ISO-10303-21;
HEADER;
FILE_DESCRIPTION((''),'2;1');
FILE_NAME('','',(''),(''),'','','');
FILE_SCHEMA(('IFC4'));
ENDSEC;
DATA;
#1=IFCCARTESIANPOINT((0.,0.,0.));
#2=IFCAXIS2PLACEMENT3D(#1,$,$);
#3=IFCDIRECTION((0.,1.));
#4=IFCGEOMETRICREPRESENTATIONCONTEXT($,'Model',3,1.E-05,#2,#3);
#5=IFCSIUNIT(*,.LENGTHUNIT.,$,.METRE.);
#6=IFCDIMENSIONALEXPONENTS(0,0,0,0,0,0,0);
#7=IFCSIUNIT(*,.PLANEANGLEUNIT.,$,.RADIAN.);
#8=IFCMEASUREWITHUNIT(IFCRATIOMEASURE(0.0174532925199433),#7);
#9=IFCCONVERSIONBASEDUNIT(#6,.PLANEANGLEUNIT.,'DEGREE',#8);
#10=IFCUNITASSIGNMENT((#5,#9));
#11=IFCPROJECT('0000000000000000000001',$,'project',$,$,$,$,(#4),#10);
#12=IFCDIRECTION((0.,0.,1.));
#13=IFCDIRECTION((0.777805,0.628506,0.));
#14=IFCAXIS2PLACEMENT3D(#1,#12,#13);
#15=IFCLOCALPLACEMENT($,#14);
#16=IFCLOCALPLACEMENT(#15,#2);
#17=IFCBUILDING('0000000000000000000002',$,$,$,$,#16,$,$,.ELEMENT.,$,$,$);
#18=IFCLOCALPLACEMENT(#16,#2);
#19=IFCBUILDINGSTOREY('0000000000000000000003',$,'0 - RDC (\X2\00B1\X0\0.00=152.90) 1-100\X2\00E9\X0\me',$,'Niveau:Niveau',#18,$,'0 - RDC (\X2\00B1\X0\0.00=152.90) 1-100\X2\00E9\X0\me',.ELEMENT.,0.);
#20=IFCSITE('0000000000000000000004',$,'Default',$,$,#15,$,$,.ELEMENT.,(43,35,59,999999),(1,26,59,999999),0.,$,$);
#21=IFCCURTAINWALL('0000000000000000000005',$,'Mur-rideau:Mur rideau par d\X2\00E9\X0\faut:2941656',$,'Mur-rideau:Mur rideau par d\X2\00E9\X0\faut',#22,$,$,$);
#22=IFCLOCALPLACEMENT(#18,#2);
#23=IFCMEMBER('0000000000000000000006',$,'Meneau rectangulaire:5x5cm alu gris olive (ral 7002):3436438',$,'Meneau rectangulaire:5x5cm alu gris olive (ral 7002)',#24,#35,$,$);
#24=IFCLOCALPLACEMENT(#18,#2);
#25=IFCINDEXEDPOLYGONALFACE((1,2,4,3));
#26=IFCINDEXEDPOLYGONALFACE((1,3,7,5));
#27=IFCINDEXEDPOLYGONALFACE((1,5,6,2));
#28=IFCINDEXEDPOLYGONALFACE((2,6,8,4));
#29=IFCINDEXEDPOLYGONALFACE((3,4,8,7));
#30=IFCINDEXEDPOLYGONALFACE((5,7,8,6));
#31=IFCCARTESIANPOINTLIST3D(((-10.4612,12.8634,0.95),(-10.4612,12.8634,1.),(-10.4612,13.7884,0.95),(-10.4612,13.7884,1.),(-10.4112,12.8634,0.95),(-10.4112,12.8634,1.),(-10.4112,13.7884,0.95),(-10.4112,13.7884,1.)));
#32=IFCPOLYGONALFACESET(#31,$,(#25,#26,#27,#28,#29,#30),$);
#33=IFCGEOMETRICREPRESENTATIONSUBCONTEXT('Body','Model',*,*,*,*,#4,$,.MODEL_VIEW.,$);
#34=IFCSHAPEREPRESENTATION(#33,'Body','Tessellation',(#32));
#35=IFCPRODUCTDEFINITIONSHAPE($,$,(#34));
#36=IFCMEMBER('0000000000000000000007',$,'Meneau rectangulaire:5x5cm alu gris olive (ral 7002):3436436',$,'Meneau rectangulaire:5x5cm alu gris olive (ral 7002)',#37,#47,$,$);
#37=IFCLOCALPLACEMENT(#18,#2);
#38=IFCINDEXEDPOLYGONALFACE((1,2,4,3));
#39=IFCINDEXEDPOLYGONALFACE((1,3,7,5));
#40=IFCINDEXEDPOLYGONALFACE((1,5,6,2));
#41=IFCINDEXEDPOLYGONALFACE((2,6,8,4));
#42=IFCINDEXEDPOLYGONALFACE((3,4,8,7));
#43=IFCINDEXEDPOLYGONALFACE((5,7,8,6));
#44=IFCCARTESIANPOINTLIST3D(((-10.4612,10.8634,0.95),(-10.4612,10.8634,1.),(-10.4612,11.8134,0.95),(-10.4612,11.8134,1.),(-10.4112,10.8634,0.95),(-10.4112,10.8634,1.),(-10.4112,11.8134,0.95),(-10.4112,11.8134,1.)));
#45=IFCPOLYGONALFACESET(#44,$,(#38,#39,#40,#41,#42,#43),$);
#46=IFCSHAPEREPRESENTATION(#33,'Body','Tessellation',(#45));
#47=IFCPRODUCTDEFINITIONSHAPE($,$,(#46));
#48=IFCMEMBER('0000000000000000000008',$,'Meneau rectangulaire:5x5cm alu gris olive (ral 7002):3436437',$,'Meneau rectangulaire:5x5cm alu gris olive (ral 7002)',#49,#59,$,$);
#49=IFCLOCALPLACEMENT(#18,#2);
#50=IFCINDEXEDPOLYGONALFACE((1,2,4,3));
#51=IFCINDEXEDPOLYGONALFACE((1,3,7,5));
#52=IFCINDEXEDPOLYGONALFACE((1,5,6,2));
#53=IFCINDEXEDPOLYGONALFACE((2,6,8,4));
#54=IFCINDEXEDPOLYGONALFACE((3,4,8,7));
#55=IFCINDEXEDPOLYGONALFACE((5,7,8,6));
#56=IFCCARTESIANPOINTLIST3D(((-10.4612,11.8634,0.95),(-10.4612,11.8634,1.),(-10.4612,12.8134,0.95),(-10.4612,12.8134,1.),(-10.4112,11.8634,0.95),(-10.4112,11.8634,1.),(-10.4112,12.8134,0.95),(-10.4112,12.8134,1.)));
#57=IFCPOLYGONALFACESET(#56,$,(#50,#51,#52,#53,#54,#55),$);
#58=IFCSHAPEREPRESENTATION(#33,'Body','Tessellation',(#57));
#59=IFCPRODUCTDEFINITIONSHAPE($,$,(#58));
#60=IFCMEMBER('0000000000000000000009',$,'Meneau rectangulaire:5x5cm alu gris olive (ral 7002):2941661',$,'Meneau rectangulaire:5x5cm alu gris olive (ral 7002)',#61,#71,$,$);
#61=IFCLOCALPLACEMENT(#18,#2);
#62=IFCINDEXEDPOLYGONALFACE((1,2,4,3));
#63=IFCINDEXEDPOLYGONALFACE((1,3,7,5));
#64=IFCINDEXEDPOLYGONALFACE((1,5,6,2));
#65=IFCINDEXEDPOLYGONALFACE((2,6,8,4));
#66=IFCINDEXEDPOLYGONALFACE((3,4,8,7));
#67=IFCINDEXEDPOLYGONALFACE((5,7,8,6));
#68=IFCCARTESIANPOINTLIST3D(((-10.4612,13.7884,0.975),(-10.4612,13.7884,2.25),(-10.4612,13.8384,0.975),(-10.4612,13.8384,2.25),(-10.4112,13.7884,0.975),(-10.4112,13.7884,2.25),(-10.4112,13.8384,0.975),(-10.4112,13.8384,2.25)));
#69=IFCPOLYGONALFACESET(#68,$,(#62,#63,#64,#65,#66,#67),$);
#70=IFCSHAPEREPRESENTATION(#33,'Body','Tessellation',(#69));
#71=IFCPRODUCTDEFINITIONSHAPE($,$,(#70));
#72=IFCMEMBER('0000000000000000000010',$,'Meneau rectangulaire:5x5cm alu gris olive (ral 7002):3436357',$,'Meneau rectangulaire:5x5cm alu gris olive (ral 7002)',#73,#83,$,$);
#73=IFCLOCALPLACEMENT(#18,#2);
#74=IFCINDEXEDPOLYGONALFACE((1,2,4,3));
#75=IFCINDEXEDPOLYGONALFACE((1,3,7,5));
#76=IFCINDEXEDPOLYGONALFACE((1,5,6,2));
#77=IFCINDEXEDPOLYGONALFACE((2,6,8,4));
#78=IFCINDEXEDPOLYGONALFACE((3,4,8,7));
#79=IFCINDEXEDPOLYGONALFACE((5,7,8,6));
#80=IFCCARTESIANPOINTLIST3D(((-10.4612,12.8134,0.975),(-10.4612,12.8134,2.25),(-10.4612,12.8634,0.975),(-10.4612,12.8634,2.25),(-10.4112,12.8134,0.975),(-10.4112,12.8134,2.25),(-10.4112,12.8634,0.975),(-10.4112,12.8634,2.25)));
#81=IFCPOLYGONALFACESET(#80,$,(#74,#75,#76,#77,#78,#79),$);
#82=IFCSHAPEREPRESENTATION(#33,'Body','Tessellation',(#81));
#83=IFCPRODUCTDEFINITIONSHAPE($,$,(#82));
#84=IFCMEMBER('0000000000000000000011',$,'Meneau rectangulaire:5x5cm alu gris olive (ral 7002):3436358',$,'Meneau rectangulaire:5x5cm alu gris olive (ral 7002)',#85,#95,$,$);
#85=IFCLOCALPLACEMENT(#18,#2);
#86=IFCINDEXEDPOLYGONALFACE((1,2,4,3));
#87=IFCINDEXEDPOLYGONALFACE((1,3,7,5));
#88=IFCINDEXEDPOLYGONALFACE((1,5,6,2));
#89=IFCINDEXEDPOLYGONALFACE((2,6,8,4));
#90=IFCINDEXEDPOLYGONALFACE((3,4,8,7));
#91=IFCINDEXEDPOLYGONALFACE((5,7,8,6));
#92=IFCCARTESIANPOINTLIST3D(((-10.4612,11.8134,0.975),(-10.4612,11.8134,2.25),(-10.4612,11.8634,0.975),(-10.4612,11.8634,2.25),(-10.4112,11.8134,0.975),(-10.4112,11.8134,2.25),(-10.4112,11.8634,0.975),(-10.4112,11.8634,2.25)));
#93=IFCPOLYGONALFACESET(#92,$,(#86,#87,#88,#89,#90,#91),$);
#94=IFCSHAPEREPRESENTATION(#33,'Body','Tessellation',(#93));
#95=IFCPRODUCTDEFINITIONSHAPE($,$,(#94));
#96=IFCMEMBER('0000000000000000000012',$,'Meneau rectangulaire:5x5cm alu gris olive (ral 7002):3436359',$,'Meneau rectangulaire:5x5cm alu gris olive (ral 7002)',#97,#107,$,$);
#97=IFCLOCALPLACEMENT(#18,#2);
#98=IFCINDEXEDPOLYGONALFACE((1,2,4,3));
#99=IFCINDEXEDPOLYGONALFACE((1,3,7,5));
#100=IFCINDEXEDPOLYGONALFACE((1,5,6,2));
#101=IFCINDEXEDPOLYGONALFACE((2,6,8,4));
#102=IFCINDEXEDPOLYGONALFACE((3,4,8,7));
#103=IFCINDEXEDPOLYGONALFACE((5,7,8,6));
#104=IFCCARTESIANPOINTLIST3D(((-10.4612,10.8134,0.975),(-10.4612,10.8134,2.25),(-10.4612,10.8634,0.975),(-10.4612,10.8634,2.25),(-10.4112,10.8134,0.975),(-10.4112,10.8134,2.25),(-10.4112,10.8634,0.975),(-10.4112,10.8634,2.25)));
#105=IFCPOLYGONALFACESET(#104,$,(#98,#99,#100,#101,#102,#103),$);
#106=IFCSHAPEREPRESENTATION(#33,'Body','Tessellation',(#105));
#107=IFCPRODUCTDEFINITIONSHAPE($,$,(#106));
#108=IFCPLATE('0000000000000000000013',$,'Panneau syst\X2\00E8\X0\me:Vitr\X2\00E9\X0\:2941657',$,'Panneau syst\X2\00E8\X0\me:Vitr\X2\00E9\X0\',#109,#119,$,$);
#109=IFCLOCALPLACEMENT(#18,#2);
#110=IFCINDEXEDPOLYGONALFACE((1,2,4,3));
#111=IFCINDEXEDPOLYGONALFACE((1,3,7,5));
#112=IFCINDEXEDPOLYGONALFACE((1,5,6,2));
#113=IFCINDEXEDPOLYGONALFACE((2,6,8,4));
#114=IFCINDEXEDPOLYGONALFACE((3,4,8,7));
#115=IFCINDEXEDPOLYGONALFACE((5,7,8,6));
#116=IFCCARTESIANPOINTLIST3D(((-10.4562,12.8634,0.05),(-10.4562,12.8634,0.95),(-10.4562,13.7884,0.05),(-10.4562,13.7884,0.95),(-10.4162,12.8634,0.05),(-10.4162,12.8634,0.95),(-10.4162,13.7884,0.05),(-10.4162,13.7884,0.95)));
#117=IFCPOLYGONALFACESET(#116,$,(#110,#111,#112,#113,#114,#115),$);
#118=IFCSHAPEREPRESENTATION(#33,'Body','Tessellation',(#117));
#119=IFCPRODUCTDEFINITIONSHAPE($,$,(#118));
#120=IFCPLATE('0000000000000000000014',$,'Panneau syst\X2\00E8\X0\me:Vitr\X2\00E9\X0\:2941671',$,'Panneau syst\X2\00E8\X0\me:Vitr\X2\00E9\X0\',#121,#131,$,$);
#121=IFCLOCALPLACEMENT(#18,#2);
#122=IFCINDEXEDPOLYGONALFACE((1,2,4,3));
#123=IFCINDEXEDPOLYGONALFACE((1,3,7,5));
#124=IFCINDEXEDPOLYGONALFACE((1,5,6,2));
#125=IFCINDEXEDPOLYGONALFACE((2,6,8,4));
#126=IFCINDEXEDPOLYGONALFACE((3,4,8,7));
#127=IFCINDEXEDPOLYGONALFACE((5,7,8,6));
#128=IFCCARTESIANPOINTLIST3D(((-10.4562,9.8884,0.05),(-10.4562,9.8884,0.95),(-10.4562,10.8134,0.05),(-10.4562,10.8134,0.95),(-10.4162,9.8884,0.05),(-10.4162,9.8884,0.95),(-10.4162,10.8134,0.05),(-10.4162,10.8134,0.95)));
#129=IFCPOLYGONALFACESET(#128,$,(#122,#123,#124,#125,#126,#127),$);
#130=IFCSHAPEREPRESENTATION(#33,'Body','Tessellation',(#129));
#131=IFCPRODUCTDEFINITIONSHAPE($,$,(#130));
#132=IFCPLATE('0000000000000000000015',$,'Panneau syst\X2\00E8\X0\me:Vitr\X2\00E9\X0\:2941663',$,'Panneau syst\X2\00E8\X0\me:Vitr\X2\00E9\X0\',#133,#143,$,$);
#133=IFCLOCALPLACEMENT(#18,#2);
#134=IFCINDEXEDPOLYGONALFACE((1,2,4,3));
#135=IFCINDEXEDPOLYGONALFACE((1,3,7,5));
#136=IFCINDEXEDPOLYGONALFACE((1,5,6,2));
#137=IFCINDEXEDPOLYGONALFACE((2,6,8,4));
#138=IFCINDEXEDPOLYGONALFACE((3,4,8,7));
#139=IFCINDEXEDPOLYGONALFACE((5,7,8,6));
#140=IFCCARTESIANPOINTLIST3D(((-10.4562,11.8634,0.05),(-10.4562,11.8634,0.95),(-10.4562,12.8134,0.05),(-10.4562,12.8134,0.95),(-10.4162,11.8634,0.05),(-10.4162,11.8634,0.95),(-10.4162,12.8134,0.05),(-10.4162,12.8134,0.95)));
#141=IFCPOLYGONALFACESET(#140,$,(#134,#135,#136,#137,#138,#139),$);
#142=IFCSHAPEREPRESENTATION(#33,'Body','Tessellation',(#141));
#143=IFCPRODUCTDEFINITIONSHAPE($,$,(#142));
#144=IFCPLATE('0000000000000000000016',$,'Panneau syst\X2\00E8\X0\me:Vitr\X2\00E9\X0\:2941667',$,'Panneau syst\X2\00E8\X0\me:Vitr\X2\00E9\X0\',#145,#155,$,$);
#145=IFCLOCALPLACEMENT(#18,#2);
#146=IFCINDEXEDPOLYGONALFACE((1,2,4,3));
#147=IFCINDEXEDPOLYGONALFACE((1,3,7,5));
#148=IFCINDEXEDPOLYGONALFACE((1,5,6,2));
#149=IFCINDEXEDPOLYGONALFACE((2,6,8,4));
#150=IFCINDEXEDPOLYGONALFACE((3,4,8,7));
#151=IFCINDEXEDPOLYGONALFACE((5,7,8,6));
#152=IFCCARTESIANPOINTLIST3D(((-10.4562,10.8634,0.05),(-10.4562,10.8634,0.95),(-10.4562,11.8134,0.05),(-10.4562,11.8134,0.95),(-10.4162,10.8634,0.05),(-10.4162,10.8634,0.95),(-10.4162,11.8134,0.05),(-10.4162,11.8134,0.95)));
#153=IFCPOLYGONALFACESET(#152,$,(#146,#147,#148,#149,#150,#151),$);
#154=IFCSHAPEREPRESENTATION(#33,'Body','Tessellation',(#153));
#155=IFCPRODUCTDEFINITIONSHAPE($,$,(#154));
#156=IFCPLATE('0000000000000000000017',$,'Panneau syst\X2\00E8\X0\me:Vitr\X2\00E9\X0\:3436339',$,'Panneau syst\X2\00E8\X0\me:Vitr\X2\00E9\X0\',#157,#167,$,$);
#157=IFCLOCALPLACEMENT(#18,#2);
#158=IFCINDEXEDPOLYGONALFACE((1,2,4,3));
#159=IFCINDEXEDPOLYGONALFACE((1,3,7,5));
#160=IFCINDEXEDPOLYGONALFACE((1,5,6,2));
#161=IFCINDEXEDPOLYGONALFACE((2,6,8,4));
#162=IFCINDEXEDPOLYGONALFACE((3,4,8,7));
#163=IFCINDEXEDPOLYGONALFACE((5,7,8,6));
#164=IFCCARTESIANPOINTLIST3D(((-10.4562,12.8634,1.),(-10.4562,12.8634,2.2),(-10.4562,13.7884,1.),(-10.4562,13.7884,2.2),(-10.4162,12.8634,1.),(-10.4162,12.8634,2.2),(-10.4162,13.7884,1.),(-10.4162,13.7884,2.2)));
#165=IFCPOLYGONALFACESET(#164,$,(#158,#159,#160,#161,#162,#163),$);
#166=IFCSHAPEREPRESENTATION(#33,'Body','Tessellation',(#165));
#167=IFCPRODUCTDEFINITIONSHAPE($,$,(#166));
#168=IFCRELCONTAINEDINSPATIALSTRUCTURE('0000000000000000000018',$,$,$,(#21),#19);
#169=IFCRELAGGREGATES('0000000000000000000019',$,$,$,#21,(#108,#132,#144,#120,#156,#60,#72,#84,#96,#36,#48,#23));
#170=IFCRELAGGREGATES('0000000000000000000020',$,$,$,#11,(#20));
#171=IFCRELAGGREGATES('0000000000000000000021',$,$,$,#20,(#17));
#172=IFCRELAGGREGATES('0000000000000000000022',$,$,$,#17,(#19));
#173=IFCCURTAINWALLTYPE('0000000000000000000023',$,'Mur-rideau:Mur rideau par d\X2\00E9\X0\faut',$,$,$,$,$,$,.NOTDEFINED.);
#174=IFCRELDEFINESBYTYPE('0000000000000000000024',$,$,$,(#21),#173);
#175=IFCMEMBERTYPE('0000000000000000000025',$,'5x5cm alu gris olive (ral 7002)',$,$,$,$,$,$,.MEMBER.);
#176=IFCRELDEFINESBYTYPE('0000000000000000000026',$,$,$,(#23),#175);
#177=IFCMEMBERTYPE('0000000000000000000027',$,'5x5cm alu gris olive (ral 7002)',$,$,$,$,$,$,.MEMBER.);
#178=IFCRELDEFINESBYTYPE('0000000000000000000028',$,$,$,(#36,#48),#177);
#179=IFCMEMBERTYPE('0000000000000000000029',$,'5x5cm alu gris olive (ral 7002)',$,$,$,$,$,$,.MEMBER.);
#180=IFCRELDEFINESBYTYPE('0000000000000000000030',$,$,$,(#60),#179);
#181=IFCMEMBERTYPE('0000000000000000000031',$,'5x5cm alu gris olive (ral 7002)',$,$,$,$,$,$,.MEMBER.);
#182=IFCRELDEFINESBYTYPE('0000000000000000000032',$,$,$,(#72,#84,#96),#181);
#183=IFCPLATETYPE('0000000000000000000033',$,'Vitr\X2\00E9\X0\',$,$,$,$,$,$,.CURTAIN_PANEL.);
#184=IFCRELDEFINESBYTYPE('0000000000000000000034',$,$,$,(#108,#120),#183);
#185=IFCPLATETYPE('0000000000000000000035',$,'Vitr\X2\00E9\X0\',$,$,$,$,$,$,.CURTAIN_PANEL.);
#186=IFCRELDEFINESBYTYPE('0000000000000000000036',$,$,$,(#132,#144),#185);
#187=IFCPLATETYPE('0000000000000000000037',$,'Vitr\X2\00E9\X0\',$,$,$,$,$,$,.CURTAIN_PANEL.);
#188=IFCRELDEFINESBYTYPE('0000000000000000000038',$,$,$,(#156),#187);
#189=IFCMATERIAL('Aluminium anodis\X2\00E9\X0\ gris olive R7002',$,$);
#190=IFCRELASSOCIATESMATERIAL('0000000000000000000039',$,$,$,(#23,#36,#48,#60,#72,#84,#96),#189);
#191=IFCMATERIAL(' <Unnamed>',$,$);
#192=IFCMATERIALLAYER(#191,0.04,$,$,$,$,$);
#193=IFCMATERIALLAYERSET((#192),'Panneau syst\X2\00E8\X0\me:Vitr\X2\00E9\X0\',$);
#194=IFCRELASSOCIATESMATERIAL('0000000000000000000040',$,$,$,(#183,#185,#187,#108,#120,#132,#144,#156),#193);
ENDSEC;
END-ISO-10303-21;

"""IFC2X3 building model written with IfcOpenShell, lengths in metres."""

from ifc_helpers import new_model, entity, si_unit, converted_unit, direction, frame, frame_2d, origin, origin_2d_with_axis, place, context, subcontext, project, spatial, rectangle, extrude, source, transform, mapped, material, layer, layer_set, layer_usage, type_object, type_shapes, element, aggregate, save


model = new_model("IFC2X3")

# Units and contexts
model_context = context("Model", 3, precision=1e-05, world=origin(), true_north=direction((0.0, 1.0)))
body_context = subcontext(model_context, "Body", "Model", "MODEL_VIEW")
ifc_project = project(units=[si_unit("LENGTHUNIT", "METRE"), converted_unit("PLANEANGLEUNIT", "DEGREE", entity("IfcRatioMeasure", 0.0174532925199433), si_unit("PLANEANGLEUNIT", "RADIAN"), dimensions=[0, 0, 0, 0, 0, 0, 0])], contexts=[model_context])

# Site, building, storey
site_placement = place(None, frame((0.0, 0.0, 0.0), z_axis=(0.0, 0.0, 1.0), x_axis=(0.777805, 0.628506, 0.0)))
site = spatial("IfcSite", under=ifc_project, at=site_placement, Name="Default", CompositionType="ELEMENT", RefLatitude=(43, 35, 59, 999999), RefLongitude=(1, 26, 59, 999999), RefElevation=0.0)
building_placement = place(site_placement, origin())
building = spatial("IfcBuilding", under=site, at=building_placement, CompositionType="ELEMENT")
storey_placement = place(building_placement, origin())
storey = spatial("IfcBuildingStorey", under=building, at=storey_placement, Name="0 - RDC (±0.00=152.90) 1-100éme", ObjectType="Niveau:Niveau", LongName="0 - RDC (±0.00=152.90) 1-100éme", CompositionType="ELEMENT", Elevation=0.0)

# Curtain wall, members, plates
curtain_wall_type = type_object("IfcCurtainWallType", Name="Mur-rideau:Mur rideau par défaut", PredefinedType="NOTDEFINED")
curtain_wall_placement = place(storey_placement, origin())
curtain_wall = element("IfcCurtainWall", 1, at=curtain_wall_placement, inside=storey, type_object=curtain_wall_type, Name="Mur-rideau:Mur rideau par défaut:2941656", ObjectType="Mur-rideau:Mur rideau par défaut")
ifc_material_1 = material(Name="Aluminium anodisé gris olive R7002")
member_type_1 = type_object("IfcMemberType", Name="5x5cm alu gris olive (ral 7002)", PredefinedType="MEMBER")
shared_shape_1 = source(origin(), body_context, "Body", "SweptSolid", [
    extrude(rectangle(XDim=0.05, YDim=0.05, at=origin_2d_with_axis()), frame((0.0, 0.0, -0.925), z_axis=(0.0, 0.0, 1.0), x_axis=(0.0, -1.0, 0.0)), (0.0, 0.0, 1.0), 0.925),
])
type_shapes(member_type_1, [shared_shape_1])
member_1_placement = place(storey_placement, frame((-10.4362, 12.8634, 0.975), z_axis=(0.0, -1.0, 0.0), x_axis=(0.0, 0.0, 1.0)))
member_1 = element("IfcMember", 2, at=member_1_placement, type_object=member_type_1, material=ifc_material_1, Name="Meneau rectangulaire:5x5cm alu gris olive (ral 7002):3436438", ObjectType="Meneau rectangulaire:5x5cm alu gris olive (ral 7002)", context=body_context, shape_type="MappedRepresentation", body=[
    mapped(shared_shape_1, transform((0.0, 0.0, 0.0), scale=1.0)),
])
member_type_2 = type_object("IfcMemberType", Name="5x5cm alu gris olive (ral 7002)", PredefinedType="MEMBER")
shared_shape_2 = source(origin(), body_context, "Body", "SweptSolid", [
    extrude(rectangle(XDim=0.05, YDim=0.05, at=origin_2d_with_axis()), frame((0.0, 0.0, -0.95), z_axis=(0.0, 0.0, 1.0), x_axis=(0.0, -1.0, 0.0)), (0.0, 0.0, 1.0), 0.95),
])
type_shapes(member_type_2, [shared_shape_2])
member_2_placement = place(storey_placement, frame((-10.4362, 10.8634, 0.975), z_axis=(0.0, -1.0, 0.0), x_axis=(0.0, 0.0, 1.0)))
member_2 = element("IfcMember", 3, at=member_2_placement, type_object=member_type_2, material=ifc_material_1, Name="Meneau rectangulaire:5x5cm alu gris olive (ral 7002):3436436", ObjectType="Meneau rectangulaire:5x5cm alu gris olive (ral 7002)", context=body_context, shape_type="MappedRepresentation", body=[
    mapped(shared_shape_2, transform((0.0, 0.0, 0.0), scale=1.0)),
])
member_3_placement = place(storey_placement, frame((-10.4362, 11.8634, 0.975), z_axis=(0.0, -1.0, 0.0), x_axis=(0.0, 0.0, 1.0)))
member_3 = element("IfcMember", 4, at=member_3_placement, type_object=member_type_2, material=ifc_material_1, Name="Meneau rectangulaire:5x5cm alu gris olive (ral 7002):3436437", ObjectType="Meneau rectangulaire:5x5cm alu gris olive (ral 7002)", context=body_context, shape_type="MappedRepresentation", body=[
    mapped(shared_shape_2, transform((0.0, 0.0, 0.0), scale=1.0)),
])
member_type_3 = type_object("IfcMemberType", Name="5x5cm alu gris olive (ral 7002)", PredefinedType="MEMBER")
shared_shape_3 = source(origin(), body_context, "Body", "SweptSolid", [
    extrude(rectangle(XDim=0.05, YDim=0.05, at=origin_2d_with_axis()), frame((-0.025, 0.0, -1.275), z_axis=(0.0, 0.0, 1.0), x_axis=(0.0, -1.0, 0.0)), (0.0, 0.0, 1.0), 1.275),
])
type_shapes(member_type_3, [shared_shape_3])
member_4_placement = place(storey_placement, frame((-10.4362, 13.8384, 2.25), z_axis=(0.0, 0.0, 1.0), x_axis=(0.0, 1.0, 0.0)))
member_4 = element("IfcMember", 5, at=member_4_placement, type_object=member_type_3, material=ifc_material_1, Name="Meneau rectangulaire:5x5cm alu gris olive (ral 7002):2941661", ObjectType="Meneau rectangulaire:5x5cm alu gris olive (ral 7002)", context=body_context, shape_type="MappedRepresentation", body=[
    mapped(shared_shape_3, transform((0.0, 0.0, 0.0), scale=1.0)),
])
member_type_4 = type_object("IfcMemberType", Name="5x5cm alu gris olive (ral 7002)", PredefinedType="MEMBER")
shared_shape_4 = source(origin(), body_context, "Body", "SweptSolid", [
    extrude(rectangle(XDim=0.05, YDim=0.05, at=origin_2d_with_axis()), frame((0.0, 0.0, -1.275), z_axis=(0.0, 0.0, 1.0), x_axis=(0.0, -1.0, 0.0)), (0.0, 0.0, 1.0), 1.275),
])
type_shapes(member_type_4, [shared_shape_4])
member_5_placement = place(storey_placement, frame((-10.4362, 12.8384, 0.975), z_axis=(0.0, 0.0, -1.0), x_axis=(0.0, -1.0, 0.0)))
member_5 = element("IfcMember", 6, at=member_5_placement, type_object=member_type_4, material=ifc_material_1, Name="Meneau rectangulaire:5x5cm alu gris olive (ral 7002):3436357", ObjectType="Meneau rectangulaire:5x5cm alu gris olive (ral 7002)", context=body_context, shape_type="MappedRepresentation", body=[
    mapped(shared_shape_4, transform((0.0, 0.0, 0.0), scale=1.0)),
])
member_6_placement = place(storey_placement, frame((-10.4362, 11.8384, 0.975), z_axis=(0.0, 0.0, -1.0), x_axis=(0.0, -1.0, 0.0)))
member_6 = element("IfcMember", 7, at=member_6_placement, type_object=member_type_4, material=ifc_material_1, Name="Meneau rectangulaire:5x5cm alu gris olive (ral 7002):3436358", ObjectType="Meneau rectangulaire:5x5cm alu gris olive (ral 7002)", context=body_context, shape_type="MappedRepresentation", body=[
    mapped(shared_shape_4, transform((0.0, 0.0, 0.0), scale=1.0)),
])
member_7_placement = place(storey_placement, frame((-10.4362, 10.8384, 0.975), z_axis=(0.0, 0.0, -1.0), x_axis=(0.0, -1.0, 0.0)))
member_7 = element("IfcMember", 8, at=member_7_placement, type_object=member_type_4, material=ifc_material_1, Name="Meneau rectangulaire:5x5cm alu gris olive (ral 7002):3436359", ObjectType="Meneau rectangulaire:5x5cm alu gris olive (ral 7002)", context=body_context, shape_type="MappedRepresentation", body=[
    mapped(shared_shape_4, transform((0.0, 0.0, 0.0), scale=1.0)),
])
ifc_material_2 = material(Name=" <Unnamed>")
ifc_layer = layer(ifc_material_2, 0.04)
ifc_layer_set = layer_set([ifc_layer], Name="Panneau système:Vitré")
ifc_layer_usage_1 = layer_usage(ifc_layer_set, "AXIS3", "POSITIVE", 0.0)
plate_type_1 = type_object("IfcPlateType", Name="Vitré", PredefinedType="CURTAIN_PANEL", material=ifc_layer_set)
shared_shape_5 = source(origin(), body_context, "Body", "SweptSolid", [
    extrude(rectangle(XDim=0.04, YDim=0.925, at=frame_2d((0.0, 0.0), x_axis=(1.0, 0.0))), frame((0.0, 0.0, 0.0), z_axis=(0.0, 0.0, 1.0), x_axis=(0.0, 1.0, 0.0)), (0.0, 0.0, 1.0), 0.9),
])
type_shapes(plate_type_1, [shared_shape_5])
plate_1_placement = place(curtain_wall_placement, frame((-10.4362, 13.3259, 0.05), z_axis=(0.0, 0.0, 1.0), x_axis=(0.0, -1.0, 0.0)))
plate_1 = element("IfcPlate", 9, at=plate_1_placement, type_object=plate_type_1, material=ifc_layer_usage_1, Name="Panneau système:Vitré:2941657", ObjectType="Panneau système:Vitré", context=body_context, shape_type="MappedRepresentation", body=[
    mapped(shared_shape_5, transform((0.0, 0.0, 0.0), scale=1.0)),
])
ifc_layer_usage_2 = layer_usage(ifc_layer_set, "AXIS3", "POSITIVE", 0.0)
plate_2_placement = place(curtain_wall_placement, frame((-10.4362, 10.3509, 0.05), z_axis=(0.0, 0.0, 1.0), x_axis=(0.0, -1.0, 0.0)))
plate_2 = element("IfcPlate", 10, at=plate_2_placement, type_object=plate_type_1, material=ifc_layer_usage_2, Name="Panneau système:Vitré:2941671", ObjectType="Panneau système:Vitré", context=body_context, shape_type="MappedRepresentation", body=[
    mapped(shared_shape_5, transform((0.0, 0.0, 0.0), scale=1.0)),
])
ifc_layer_usage_3 = layer_usage(ifc_layer_set, "AXIS3", "POSITIVE", 0.0)
plate_type_2 = type_object("IfcPlateType", Name="Vitré", PredefinedType="CURTAIN_PANEL", material=ifc_layer_set)
shared_shape_6 = source(origin(), body_context, "Body", "SweptSolid", [
    extrude(rectangle(XDim=0.04, YDim=0.95, at=frame_2d((0.0, 0.0), x_axis=(1.0, 0.0))), frame((0.0, 0.0, 0.0), z_axis=(0.0, 0.0, 1.0), x_axis=(0.0, 1.0, 0.0)), (0.0, 0.0, 1.0), 0.9),
])
type_shapes(plate_type_2, [shared_shape_6])
plate_3_placement = place(curtain_wall_placement, frame((-10.4362, 12.3384, 0.05), z_axis=(0.0, 0.0, 1.0), x_axis=(0.0, -1.0, 0.0)))
plate_3 = element("IfcPlate", 11, at=plate_3_placement, type_object=plate_type_2, material=ifc_layer_usage_3, Name="Panneau système:Vitré:2941663", ObjectType="Panneau système:Vitré", context=body_context, shape_type="MappedRepresentation", body=[
    mapped(shared_shape_6, transform((0.0, 0.0, 0.0), scale=1.0)),
])
ifc_layer_usage_4 = layer_usage(ifc_layer_set, "AXIS3", "POSITIVE", 0.0)
plate_4_placement = place(curtain_wall_placement, frame((-10.4362, 11.3384, 0.05), z_axis=(0.0, 0.0, 1.0), x_axis=(0.0, -1.0, 0.0)))
plate_4 = element("IfcPlate", 12, at=plate_4_placement, type_object=plate_type_2, material=ifc_layer_usage_4, Name="Panneau système:Vitré:2941667", ObjectType="Panneau système:Vitré", context=body_context, shape_type="MappedRepresentation", body=[
    mapped(shared_shape_6, transform((0.0, 0.0, 0.0), scale=1.0)),
])
ifc_layer_usage_5 = layer_usage(ifc_layer_set, "AXIS3", "POSITIVE", 0.0)
plate_type_3 = type_object("IfcPlateType", Name="Vitré", PredefinedType="CURTAIN_PANEL", material=ifc_layer_set)
shared_shape_7 = source(origin(), body_context, "Body", "SweptSolid", [
    extrude(rectangle(XDim=0.04, YDim=0.925, at=frame_2d((0.0, 0.0), x_axis=(1.0, 0.0))), frame((0.0, 0.0, 0.0), z_axis=(0.0, 0.0, 1.0), x_axis=(0.0, 1.0, 0.0)), (0.0, 0.0, 1.0), 1.2),
])
type_shapes(plate_type_3, [shared_shape_7])
plate_5_placement = place(curtain_wall_placement, frame((-10.4362, 13.3259, 1.0), z_axis=(0.0, 0.0, 1.0), x_axis=(0.0, -1.0, 0.0)))
plate_5 = element("IfcPlate", 13, at=plate_5_placement, type_object=plate_type_3, material=ifc_layer_usage_5, Name="Panneau système:Vitré:3436339", ObjectType="Panneau système:Vitré", context=body_context, shape_type="MappedRepresentation", body=[
    mapped(shared_shape_7, transform((0.0, 0.0, 0.0), scale=1.0)),
])
aggregate(curtain_wall, [plate_1, plate_3, plate_4, plate_2, plate_5, member_4, member_5, member_6, member_7, member_2, member_3, member_1])

save(model, "model.ifc")
